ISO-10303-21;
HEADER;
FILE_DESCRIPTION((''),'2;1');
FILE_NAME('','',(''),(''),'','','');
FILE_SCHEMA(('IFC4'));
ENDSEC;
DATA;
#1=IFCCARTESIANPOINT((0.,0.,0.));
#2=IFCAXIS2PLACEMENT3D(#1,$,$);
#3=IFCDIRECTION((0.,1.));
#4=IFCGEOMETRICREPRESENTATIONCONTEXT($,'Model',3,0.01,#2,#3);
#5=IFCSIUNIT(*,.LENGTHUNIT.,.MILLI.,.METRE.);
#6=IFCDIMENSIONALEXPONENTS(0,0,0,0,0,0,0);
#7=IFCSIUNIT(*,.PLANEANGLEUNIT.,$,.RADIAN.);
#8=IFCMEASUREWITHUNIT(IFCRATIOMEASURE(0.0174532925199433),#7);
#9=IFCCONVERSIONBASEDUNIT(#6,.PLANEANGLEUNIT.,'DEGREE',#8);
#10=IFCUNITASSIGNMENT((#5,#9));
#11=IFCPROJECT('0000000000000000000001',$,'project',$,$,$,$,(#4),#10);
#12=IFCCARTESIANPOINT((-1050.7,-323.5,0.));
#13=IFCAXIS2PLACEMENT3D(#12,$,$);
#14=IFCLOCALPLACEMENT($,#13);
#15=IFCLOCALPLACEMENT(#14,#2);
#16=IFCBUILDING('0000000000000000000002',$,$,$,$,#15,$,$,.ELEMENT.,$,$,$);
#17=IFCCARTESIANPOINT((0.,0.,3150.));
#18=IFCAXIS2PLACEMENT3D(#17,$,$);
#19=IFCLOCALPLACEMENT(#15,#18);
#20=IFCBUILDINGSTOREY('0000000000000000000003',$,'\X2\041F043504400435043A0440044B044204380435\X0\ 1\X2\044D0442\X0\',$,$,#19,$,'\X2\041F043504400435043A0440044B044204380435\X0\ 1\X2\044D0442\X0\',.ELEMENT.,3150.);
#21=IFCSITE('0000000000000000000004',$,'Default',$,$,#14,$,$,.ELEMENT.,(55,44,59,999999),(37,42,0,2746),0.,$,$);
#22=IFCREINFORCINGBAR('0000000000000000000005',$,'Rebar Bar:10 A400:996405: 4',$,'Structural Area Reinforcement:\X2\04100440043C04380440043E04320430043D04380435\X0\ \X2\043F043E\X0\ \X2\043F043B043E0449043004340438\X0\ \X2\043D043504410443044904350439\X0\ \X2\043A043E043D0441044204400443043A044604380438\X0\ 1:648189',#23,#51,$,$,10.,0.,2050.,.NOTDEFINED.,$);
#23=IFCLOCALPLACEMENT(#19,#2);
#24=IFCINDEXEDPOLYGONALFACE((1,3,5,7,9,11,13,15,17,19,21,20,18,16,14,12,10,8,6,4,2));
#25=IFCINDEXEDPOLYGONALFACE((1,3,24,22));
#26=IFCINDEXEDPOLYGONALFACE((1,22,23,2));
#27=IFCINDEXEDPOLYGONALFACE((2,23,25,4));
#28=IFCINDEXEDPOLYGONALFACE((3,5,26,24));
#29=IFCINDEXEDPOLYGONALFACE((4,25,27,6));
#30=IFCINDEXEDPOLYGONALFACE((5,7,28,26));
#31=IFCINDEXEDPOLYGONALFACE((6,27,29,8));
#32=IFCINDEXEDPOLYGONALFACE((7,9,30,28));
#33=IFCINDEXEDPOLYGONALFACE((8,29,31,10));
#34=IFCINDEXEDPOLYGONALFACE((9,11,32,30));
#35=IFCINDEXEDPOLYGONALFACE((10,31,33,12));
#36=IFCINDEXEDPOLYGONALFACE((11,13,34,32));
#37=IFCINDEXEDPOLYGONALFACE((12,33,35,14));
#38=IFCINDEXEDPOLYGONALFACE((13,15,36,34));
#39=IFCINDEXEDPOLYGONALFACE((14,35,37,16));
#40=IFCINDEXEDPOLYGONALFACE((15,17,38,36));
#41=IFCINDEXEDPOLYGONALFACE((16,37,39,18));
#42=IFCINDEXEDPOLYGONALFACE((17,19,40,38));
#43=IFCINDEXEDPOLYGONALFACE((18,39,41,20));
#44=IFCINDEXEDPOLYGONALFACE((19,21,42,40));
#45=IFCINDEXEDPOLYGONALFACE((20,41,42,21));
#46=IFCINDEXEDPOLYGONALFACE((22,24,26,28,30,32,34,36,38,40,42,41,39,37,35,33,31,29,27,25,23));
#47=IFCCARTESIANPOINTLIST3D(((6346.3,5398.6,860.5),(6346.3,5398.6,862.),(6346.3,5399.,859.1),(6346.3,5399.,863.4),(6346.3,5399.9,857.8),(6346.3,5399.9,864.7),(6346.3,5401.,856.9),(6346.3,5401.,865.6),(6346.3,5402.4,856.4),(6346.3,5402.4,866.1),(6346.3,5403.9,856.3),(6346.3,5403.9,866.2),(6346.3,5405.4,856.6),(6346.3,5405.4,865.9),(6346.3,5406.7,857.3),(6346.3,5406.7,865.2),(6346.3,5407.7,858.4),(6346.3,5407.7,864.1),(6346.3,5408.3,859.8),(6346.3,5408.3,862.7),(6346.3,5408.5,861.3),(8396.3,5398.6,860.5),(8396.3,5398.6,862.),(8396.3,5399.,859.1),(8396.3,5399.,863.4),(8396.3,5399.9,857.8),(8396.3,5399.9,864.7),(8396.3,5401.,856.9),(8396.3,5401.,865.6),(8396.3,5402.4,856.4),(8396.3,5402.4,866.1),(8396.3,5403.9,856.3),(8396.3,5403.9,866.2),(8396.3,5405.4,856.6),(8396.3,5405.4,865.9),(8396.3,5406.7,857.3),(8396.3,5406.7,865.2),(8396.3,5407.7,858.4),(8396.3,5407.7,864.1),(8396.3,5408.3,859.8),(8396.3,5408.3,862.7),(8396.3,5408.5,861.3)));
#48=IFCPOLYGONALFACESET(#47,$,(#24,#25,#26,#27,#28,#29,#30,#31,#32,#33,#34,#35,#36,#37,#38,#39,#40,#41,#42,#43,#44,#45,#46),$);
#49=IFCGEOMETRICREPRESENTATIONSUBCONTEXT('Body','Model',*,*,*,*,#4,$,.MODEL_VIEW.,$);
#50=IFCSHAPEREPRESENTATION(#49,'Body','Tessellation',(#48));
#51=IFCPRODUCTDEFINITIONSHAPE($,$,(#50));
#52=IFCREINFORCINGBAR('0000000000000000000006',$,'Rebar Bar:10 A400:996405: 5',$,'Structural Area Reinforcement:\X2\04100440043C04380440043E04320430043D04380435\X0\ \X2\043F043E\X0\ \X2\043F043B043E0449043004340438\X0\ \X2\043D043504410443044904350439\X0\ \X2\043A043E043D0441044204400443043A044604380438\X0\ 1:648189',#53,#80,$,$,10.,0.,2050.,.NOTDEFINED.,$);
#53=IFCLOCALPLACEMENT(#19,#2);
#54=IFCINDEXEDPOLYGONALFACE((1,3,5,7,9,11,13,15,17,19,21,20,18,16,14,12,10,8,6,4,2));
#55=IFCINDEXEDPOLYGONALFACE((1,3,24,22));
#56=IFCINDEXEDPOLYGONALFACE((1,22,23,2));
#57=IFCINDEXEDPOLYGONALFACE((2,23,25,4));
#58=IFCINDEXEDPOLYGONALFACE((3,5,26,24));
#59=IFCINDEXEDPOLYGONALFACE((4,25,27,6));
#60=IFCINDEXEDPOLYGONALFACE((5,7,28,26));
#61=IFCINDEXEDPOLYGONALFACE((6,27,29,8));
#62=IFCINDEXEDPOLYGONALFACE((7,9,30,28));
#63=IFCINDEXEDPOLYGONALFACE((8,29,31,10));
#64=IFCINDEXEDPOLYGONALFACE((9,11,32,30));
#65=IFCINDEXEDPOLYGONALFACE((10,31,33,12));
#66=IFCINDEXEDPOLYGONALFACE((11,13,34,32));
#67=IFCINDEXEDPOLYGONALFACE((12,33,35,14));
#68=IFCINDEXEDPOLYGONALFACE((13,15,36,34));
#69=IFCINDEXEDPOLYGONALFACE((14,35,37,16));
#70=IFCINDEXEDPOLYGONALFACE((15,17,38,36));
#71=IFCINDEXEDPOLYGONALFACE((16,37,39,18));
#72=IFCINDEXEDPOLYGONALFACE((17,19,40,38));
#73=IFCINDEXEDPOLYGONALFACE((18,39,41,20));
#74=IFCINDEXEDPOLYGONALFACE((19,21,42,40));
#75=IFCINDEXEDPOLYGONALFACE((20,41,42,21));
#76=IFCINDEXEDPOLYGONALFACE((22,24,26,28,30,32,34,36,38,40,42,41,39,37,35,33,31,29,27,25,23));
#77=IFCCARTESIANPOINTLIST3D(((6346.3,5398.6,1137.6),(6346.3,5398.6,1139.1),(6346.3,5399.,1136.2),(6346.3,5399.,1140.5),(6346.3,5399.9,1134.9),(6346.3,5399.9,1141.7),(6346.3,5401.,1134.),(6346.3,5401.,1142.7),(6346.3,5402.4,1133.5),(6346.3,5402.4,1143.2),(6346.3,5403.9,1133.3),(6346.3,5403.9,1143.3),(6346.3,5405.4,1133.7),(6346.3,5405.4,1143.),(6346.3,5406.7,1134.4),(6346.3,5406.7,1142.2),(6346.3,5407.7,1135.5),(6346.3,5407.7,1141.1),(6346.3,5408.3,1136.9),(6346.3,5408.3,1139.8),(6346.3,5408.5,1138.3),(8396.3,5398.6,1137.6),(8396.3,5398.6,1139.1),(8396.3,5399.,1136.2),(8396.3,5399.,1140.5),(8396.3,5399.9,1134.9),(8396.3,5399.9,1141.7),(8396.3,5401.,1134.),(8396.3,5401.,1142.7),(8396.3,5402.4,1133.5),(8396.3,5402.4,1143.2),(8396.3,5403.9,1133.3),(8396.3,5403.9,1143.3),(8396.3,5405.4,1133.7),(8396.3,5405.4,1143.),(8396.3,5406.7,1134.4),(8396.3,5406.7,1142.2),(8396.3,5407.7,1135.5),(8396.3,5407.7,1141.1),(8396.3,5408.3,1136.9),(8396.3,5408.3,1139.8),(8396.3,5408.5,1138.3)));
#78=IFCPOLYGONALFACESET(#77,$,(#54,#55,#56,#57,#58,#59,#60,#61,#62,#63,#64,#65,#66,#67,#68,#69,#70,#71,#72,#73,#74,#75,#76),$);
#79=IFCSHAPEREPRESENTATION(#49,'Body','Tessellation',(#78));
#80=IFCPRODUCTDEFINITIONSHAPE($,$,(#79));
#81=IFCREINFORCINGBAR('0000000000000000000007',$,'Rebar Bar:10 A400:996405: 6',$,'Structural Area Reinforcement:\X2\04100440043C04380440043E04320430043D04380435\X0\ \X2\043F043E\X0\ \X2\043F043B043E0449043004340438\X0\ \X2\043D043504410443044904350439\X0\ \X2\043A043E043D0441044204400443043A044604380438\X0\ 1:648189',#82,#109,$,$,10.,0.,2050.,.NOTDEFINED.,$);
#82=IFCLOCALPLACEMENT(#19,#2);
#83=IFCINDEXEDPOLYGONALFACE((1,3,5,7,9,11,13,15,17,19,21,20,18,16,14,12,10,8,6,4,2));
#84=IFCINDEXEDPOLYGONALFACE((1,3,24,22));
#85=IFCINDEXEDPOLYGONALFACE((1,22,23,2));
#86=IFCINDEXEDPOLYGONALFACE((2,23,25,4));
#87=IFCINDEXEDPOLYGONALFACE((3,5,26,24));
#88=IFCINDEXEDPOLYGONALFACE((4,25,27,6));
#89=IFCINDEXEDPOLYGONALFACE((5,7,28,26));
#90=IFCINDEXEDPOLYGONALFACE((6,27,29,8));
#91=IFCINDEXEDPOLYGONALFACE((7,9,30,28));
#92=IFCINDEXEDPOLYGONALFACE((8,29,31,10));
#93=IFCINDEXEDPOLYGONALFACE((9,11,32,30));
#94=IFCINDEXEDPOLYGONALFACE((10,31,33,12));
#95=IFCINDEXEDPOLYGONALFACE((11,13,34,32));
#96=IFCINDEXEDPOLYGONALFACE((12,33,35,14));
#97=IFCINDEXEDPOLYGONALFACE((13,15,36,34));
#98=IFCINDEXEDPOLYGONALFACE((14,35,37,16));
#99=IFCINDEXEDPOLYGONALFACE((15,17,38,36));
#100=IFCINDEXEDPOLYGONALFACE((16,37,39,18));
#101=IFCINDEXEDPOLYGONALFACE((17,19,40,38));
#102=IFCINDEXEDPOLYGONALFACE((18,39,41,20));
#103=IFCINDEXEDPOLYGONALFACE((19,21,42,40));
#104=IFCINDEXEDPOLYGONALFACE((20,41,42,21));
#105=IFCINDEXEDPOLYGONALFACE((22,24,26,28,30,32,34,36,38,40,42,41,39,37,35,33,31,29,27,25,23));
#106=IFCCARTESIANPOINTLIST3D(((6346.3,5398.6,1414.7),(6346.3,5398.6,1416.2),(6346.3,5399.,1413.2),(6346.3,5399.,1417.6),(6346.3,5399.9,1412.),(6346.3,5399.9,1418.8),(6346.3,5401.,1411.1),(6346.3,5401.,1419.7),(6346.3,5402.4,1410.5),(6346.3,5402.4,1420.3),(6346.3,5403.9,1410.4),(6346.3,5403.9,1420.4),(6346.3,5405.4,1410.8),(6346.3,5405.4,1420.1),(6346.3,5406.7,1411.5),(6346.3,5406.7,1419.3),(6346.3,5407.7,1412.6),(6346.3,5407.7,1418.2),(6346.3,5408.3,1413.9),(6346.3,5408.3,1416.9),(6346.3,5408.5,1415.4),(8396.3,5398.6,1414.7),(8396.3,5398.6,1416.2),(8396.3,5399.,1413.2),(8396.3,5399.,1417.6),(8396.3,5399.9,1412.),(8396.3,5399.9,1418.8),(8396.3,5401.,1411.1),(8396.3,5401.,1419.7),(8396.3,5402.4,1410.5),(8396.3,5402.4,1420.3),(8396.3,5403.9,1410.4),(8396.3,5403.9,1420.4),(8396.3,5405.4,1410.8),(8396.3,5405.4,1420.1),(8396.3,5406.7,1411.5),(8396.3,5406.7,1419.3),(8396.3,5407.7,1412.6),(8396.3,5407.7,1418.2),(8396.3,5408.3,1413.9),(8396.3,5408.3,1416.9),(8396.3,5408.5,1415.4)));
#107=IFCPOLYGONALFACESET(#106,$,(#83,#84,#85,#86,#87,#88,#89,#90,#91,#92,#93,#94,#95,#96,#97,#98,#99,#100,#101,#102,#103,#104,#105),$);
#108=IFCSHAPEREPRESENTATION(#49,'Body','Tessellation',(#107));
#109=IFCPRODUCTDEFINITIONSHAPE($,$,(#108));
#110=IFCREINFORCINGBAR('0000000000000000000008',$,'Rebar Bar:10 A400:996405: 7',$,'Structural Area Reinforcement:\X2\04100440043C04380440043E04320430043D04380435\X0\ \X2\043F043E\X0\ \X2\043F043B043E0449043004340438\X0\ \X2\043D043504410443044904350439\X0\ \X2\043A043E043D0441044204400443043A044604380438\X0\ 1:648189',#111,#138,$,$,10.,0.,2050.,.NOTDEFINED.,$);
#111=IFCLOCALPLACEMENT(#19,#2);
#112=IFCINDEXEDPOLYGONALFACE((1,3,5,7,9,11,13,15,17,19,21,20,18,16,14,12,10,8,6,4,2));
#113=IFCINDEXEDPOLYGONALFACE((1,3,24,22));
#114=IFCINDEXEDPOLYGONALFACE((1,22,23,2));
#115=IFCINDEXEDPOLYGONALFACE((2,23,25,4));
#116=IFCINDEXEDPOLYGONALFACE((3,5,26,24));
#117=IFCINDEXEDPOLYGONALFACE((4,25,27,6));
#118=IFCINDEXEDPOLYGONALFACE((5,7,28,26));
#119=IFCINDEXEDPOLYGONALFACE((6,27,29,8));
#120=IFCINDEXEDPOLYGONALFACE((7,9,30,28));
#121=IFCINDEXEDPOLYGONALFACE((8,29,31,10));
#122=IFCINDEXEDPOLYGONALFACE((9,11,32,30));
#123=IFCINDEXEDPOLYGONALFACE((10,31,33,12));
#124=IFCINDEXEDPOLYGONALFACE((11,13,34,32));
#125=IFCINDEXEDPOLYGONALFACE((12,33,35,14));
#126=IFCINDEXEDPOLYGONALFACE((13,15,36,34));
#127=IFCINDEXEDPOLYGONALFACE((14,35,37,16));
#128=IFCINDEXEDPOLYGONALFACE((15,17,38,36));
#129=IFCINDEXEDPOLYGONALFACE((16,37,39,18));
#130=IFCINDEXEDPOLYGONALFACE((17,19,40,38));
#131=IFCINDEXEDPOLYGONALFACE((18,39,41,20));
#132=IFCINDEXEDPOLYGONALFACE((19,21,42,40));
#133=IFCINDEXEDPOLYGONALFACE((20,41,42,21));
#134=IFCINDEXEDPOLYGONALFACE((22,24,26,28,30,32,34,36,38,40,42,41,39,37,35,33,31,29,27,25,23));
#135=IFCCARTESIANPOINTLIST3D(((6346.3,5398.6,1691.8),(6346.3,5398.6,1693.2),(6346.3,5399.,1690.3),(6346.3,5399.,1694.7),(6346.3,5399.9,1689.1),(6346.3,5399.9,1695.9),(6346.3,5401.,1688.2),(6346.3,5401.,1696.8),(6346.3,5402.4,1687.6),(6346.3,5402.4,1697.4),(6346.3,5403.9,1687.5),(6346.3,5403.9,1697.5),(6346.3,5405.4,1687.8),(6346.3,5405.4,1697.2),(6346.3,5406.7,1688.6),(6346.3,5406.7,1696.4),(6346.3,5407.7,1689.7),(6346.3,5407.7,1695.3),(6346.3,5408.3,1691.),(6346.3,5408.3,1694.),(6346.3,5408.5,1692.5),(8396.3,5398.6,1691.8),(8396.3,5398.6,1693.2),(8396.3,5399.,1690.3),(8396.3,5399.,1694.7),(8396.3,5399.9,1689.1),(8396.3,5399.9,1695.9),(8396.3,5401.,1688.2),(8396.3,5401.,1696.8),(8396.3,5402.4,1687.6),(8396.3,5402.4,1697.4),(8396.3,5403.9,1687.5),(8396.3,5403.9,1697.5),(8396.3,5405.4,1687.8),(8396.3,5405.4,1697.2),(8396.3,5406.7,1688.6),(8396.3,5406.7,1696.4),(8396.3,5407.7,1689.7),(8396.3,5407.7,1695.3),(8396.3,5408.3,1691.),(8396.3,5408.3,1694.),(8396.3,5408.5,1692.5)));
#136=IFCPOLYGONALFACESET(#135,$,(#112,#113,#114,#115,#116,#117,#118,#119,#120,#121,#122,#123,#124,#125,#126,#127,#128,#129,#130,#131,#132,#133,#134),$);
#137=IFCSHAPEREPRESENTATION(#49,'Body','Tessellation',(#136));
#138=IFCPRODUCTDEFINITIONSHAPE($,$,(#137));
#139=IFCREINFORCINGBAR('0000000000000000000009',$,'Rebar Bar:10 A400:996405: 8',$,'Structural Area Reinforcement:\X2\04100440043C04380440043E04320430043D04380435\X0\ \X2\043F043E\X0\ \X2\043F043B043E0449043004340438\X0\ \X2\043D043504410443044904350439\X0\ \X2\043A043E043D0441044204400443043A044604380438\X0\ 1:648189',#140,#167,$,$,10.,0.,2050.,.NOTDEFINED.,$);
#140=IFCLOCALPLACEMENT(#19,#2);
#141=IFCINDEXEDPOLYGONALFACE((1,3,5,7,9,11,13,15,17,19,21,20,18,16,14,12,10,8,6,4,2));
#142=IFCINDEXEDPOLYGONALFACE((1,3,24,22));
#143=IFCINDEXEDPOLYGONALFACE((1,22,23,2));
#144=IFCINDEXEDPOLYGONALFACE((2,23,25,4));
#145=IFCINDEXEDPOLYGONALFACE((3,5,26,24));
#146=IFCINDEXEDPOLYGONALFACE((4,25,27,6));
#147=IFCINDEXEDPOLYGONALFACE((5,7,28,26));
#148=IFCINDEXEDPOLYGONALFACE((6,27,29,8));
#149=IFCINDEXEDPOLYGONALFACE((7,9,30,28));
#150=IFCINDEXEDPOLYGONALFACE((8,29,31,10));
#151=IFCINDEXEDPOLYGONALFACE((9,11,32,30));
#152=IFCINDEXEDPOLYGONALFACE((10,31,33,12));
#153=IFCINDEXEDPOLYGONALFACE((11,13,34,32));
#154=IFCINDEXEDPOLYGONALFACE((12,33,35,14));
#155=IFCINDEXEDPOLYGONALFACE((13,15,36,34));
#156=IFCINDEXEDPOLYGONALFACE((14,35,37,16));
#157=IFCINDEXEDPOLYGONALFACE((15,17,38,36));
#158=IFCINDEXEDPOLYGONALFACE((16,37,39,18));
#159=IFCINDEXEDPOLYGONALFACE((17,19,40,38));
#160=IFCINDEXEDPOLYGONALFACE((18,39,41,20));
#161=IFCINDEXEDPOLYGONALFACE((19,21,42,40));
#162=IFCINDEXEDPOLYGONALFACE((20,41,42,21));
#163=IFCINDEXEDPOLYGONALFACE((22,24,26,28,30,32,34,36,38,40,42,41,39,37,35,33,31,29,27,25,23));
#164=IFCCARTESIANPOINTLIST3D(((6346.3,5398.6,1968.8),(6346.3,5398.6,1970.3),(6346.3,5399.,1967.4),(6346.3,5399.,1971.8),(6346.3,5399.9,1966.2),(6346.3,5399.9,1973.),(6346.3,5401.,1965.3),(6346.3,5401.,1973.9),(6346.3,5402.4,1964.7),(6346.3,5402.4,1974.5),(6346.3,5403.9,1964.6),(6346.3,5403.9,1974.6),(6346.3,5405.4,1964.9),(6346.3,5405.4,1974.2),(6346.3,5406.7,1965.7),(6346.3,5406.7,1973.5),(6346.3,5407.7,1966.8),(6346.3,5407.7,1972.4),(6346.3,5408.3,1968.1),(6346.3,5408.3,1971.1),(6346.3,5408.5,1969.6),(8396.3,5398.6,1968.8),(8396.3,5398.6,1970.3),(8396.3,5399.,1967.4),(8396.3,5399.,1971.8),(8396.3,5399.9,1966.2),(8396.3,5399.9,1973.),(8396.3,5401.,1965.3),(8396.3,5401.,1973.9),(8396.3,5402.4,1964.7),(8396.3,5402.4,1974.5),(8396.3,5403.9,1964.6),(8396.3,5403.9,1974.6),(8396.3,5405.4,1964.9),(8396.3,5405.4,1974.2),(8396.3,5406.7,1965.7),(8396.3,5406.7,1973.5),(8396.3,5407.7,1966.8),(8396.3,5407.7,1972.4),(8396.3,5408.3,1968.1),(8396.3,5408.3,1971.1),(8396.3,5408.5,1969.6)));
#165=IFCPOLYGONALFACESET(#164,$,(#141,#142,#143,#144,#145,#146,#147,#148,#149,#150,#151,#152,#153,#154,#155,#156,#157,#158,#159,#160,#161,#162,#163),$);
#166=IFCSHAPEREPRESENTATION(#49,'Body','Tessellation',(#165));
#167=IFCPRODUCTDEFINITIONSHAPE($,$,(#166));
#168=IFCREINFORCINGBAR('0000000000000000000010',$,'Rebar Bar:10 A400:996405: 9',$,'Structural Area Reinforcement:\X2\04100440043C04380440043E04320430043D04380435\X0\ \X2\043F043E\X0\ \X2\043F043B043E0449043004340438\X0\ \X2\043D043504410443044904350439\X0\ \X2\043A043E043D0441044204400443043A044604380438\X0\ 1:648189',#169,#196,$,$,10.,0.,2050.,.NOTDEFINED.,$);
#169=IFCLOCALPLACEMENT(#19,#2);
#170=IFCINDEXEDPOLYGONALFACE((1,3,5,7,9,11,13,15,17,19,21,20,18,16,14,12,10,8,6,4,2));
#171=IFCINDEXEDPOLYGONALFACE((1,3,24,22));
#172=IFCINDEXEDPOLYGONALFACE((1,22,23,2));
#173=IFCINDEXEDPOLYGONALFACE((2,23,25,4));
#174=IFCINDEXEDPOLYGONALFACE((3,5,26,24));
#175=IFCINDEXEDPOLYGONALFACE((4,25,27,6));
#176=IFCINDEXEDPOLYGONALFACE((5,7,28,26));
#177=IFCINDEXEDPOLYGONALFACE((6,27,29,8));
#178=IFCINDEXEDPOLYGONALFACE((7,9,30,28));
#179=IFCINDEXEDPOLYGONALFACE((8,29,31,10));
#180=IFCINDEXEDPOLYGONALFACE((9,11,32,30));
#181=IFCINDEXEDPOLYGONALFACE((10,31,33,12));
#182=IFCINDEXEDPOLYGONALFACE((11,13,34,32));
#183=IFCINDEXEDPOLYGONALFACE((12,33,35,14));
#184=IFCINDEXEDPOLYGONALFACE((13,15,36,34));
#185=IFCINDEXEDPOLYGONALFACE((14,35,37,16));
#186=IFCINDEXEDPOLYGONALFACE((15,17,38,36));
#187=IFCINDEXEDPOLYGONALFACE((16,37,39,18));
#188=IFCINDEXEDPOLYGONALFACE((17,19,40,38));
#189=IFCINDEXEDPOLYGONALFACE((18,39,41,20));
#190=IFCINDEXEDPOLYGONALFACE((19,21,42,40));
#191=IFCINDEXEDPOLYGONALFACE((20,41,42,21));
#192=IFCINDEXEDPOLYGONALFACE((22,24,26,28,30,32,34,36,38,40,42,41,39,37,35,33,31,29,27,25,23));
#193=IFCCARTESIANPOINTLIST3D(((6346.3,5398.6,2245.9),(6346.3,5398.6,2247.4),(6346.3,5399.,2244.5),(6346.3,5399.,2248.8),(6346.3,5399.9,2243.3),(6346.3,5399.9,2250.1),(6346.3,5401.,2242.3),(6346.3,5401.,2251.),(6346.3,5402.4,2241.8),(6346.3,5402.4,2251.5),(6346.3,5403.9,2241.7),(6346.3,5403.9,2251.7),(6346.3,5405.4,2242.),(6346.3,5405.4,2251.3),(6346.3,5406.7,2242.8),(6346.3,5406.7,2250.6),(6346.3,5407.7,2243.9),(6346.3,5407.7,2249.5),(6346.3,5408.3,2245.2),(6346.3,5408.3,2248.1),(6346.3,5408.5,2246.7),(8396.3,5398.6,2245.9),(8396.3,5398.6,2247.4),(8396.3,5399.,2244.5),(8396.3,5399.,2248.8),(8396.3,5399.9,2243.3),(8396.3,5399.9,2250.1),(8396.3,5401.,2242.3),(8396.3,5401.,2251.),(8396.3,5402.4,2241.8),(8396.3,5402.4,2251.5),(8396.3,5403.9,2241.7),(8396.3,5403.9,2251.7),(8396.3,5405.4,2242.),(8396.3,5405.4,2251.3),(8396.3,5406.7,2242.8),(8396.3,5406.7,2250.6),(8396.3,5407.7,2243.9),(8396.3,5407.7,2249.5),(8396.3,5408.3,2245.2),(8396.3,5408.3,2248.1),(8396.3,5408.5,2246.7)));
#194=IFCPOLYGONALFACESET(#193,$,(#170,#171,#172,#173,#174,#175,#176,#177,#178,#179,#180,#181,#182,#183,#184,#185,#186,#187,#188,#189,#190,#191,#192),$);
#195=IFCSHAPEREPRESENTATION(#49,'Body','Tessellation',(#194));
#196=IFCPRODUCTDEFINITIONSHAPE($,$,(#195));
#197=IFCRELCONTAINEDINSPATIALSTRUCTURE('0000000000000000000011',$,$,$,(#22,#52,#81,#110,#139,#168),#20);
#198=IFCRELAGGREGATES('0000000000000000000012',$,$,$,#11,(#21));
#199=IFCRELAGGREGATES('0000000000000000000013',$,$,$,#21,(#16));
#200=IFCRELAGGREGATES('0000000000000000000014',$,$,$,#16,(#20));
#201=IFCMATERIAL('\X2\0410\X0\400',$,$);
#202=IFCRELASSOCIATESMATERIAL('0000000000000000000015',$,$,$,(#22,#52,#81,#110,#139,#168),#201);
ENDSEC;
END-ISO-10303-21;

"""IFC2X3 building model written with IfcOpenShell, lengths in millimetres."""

from ifc_helpers import new_model, entity, si_unit, converted_unit, direction, frame, origin, place, context, subcontext, project, spatial, material, element, save


model = new_model("IFC2X3")

# Units and contexts
model_context = context("Model", 3, precision=0.01, world=origin(), true_north=direction((0.0, 1.0)))
body_context = subcontext(model_context, "Body", "Model", "MODEL_VIEW")
ifc_project = project(units=[si_unit("LENGTHUNIT", "METRE", prefix="MILLI"), converted_unit("PLANEANGLEUNIT", "DEGREE", entity("IfcRatioMeasure", 0.0174532925199433), si_unit("PLANEANGLEUNIT", "RADIAN"), dimensions=[0, 0, 0, 0, 0, 0, 0])], contexts=[model_context])

# Site, building, storey
site_placement = place(None, frame((-1050.7, -323.5, 0.0)))
site = spatial("IfcSite", under=ifc_project, at=site_placement, Name="Default", CompositionType="ELEMENT", RefLatitude=(55, 44, 59, 999999), RefLongitude=(37, 42, 0, 2746), RefElevation=0.0)
building_placement = place(site_placement, origin())
building = spatial("IfcBuilding", under=site, at=building_placement, CompositionType="ELEMENT")
storey_placement = place(building_placement, frame((0.0, 0.0, 3150.0)))
storey = spatial("IfcBuildingStorey", under=building, at=storey_placement, Name="Перекрытие 1эт", LongName="Перекрытие 1эт", CompositionType="ELEMENT", Elevation=3150.0)

# Reinforcing bars
ifc_material = material(Name="А400")
reinforcing_bar_1_placement = place(storey_placement, origin())
element("IfcReinforcingBar", 1, at=reinforcing_bar_1_placement, inside=storey, material=ifc_material, Name="Rebar Bar:10 A400:996405: 4", ObjectType="Structural Area Reinforcement:Армирование по площади несущей конструкции 1:648189", BarLength=2050.0, BarRole="NOTDEFINED", CrossSectionArea=0.0, NominalDiameter=10.0, context=body_context, shape_type="AdvancedSweptSolid", body=[
    entity("IfcSweptDiskSolid", entity("IfcCompositeCurve", [entity("IfcCompositeCurveSegment", "CONTINUOUS", True, entity("IfcPolyline", [entity("IfcCartesianPoint", [6346.3, 5403.5, 861.3]), entity("IfcCartesianPoint", [8396.3, 5403.5, 861.3])]))], False), 5.0, None, 0.0, 1.0),
])
reinforcing_bar_2_placement = place(storey_placement, origin())
element("IfcReinforcingBar", 2, at=reinforcing_bar_2_placement, inside=storey, material=ifc_material, Name="Rebar Bar:10 A400:996405: 5", ObjectType="Structural Area Reinforcement:Армирование по площади несущей конструкции 1:648189", BarLength=2050.0, BarRole="NOTDEFINED", CrossSectionArea=0.0, NominalDiameter=10.0, context=body_context, shape_type="AdvancedSweptSolid", body=[
    entity("IfcSweptDiskSolid", entity("IfcCompositeCurve", [entity("IfcCompositeCurveSegment", "CONTINUOUS", True, entity("IfcPolyline", [entity("IfcCartesianPoint", [6346.3, 5403.5, 1138.3]), entity("IfcCartesianPoint", [8396.3, 5403.5, 1138.3])]))], False), 5.0, None, 0.0, 1.0),
])
reinforcing_bar_3_placement = place(storey_placement, origin())
element("IfcReinforcingBar", 3, at=reinforcing_bar_3_placement, inside=storey, material=ifc_material, Name="Rebar Bar:10 A400:996405: 6", ObjectType="Structural Area Reinforcement:Армирование по площади несущей конструкции 1:648189", BarLength=2050.0, BarRole="NOTDEFINED", CrossSectionArea=0.0, NominalDiameter=10.0, context=body_context, shape_type="AdvancedSweptSolid", body=[
    entity("IfcSweptDiskSolid", entity("IfcCompositeCurve", [entity("IfcCompositeCurveSegment", "CONTINUOUS", True, entity("IfcPolyline", [entity("IfcCartesianPoint", [6346.3, 5403.5, 1415.4]), entity("IfcCartesianPoint", [8396.3, 5403.5, 1415.4])]))], False), 5.0, None, 0.0, 1.0),
])
reinforcing_bar_4_placement = place(storey_placement, origin())
element("IfcReinforcingBar", 4, at=reinforcing_bar_4_placement, inside=storey, material=ifc_material, Name="Rebar Bar:10 A400:996405: 7", ObjectType="Structural Area Reinforcement:Армирование по площади несущей конструкции 1:648189", BarLength=2050.0, BarRole="NOTDEFINED", CrossSectionArea=0.0, NominalDiameter=10.0, context=body_context, shape_type="AdvancedSweptSolid", body=[
    entity("IfcSweptDiskSolid", entity("IfcCompositeCurve", [entity("IfcCompositeCurveSegment", "CONTINUOUS", True, entity("IfcPolyline", [entity("IfcCartesianPoint", [6346.3, 5403.5, 1692.5]), entity("IfcCartesianPoint", [8396.3, 5403.5, 1692.5])]))], False), 5.0, None, 0.0, 1.0),
])
reinforcing_bar_5_placement = place(storey_placement, origin())
element("IfcReinforcingBar", 5, at=reinforcing_bar_5_placement, inside=storey, material=ifc_material, Name="Rebar Bar:10 A400:996405: 8", ObjectType="Structural Area Reinforcement:Армирование по площади несущей конструкции 1:648189", BarLength=2050.0, BarRole="NOTDEFINED", CrossSectionArea=0.0, NominalDiameter=10.0, context=body_context, shape_type="AdvancedSweptSolid", body=[
    entity("IfcSweptDiskSolid", entity("IfcCompositeCurve", [entity("IfcCompositeCurveSegment", "CONTINUOUS", True, entity("IfcPolyline", [entity("IfcCartesianPoint", [6346.3, 5403.5, 1969.6]), entity("IfcCartesianPoint", [8396.3, 5403.5, 1969.6])]))], False), 5.0, None, 0.0, 1.0),
])
reinforcing_bar_6_placement = place(storey_placement, origin())
element("IfcReinforcingBar", 6, at=reinforcing_bar_6_placement, inside=storey, material=ifc_material, Name="Rebar Bar:10 A400:996405: 9", ObjectType="Structural Area Reinforcement:Армирование по площади несущей конструкции 1:648189", BarLength=2050.0, BarRole="NOTDEFINED", CrossSectionArea=0.0, NominalDiameter=10.0, context=body_context, shape_type="AdvancedSweptSolid", body=[
    entity("IfcSweptDiskSolid", entity("IfcCompositeCurve", [entity("IfcCompositeCurveSegment", "CONTINUOUS", True, entity("IfcPolyline", [entity("IfcCartesianPoint", [6346.3, 5403.5, 2246.7]), entity("IfcCartesianPoint", [8396.3, 5403.5, 2246.7])]))], False), 5.0, None, 0.0, 1.0),
])

save(model, "model.ifc")
